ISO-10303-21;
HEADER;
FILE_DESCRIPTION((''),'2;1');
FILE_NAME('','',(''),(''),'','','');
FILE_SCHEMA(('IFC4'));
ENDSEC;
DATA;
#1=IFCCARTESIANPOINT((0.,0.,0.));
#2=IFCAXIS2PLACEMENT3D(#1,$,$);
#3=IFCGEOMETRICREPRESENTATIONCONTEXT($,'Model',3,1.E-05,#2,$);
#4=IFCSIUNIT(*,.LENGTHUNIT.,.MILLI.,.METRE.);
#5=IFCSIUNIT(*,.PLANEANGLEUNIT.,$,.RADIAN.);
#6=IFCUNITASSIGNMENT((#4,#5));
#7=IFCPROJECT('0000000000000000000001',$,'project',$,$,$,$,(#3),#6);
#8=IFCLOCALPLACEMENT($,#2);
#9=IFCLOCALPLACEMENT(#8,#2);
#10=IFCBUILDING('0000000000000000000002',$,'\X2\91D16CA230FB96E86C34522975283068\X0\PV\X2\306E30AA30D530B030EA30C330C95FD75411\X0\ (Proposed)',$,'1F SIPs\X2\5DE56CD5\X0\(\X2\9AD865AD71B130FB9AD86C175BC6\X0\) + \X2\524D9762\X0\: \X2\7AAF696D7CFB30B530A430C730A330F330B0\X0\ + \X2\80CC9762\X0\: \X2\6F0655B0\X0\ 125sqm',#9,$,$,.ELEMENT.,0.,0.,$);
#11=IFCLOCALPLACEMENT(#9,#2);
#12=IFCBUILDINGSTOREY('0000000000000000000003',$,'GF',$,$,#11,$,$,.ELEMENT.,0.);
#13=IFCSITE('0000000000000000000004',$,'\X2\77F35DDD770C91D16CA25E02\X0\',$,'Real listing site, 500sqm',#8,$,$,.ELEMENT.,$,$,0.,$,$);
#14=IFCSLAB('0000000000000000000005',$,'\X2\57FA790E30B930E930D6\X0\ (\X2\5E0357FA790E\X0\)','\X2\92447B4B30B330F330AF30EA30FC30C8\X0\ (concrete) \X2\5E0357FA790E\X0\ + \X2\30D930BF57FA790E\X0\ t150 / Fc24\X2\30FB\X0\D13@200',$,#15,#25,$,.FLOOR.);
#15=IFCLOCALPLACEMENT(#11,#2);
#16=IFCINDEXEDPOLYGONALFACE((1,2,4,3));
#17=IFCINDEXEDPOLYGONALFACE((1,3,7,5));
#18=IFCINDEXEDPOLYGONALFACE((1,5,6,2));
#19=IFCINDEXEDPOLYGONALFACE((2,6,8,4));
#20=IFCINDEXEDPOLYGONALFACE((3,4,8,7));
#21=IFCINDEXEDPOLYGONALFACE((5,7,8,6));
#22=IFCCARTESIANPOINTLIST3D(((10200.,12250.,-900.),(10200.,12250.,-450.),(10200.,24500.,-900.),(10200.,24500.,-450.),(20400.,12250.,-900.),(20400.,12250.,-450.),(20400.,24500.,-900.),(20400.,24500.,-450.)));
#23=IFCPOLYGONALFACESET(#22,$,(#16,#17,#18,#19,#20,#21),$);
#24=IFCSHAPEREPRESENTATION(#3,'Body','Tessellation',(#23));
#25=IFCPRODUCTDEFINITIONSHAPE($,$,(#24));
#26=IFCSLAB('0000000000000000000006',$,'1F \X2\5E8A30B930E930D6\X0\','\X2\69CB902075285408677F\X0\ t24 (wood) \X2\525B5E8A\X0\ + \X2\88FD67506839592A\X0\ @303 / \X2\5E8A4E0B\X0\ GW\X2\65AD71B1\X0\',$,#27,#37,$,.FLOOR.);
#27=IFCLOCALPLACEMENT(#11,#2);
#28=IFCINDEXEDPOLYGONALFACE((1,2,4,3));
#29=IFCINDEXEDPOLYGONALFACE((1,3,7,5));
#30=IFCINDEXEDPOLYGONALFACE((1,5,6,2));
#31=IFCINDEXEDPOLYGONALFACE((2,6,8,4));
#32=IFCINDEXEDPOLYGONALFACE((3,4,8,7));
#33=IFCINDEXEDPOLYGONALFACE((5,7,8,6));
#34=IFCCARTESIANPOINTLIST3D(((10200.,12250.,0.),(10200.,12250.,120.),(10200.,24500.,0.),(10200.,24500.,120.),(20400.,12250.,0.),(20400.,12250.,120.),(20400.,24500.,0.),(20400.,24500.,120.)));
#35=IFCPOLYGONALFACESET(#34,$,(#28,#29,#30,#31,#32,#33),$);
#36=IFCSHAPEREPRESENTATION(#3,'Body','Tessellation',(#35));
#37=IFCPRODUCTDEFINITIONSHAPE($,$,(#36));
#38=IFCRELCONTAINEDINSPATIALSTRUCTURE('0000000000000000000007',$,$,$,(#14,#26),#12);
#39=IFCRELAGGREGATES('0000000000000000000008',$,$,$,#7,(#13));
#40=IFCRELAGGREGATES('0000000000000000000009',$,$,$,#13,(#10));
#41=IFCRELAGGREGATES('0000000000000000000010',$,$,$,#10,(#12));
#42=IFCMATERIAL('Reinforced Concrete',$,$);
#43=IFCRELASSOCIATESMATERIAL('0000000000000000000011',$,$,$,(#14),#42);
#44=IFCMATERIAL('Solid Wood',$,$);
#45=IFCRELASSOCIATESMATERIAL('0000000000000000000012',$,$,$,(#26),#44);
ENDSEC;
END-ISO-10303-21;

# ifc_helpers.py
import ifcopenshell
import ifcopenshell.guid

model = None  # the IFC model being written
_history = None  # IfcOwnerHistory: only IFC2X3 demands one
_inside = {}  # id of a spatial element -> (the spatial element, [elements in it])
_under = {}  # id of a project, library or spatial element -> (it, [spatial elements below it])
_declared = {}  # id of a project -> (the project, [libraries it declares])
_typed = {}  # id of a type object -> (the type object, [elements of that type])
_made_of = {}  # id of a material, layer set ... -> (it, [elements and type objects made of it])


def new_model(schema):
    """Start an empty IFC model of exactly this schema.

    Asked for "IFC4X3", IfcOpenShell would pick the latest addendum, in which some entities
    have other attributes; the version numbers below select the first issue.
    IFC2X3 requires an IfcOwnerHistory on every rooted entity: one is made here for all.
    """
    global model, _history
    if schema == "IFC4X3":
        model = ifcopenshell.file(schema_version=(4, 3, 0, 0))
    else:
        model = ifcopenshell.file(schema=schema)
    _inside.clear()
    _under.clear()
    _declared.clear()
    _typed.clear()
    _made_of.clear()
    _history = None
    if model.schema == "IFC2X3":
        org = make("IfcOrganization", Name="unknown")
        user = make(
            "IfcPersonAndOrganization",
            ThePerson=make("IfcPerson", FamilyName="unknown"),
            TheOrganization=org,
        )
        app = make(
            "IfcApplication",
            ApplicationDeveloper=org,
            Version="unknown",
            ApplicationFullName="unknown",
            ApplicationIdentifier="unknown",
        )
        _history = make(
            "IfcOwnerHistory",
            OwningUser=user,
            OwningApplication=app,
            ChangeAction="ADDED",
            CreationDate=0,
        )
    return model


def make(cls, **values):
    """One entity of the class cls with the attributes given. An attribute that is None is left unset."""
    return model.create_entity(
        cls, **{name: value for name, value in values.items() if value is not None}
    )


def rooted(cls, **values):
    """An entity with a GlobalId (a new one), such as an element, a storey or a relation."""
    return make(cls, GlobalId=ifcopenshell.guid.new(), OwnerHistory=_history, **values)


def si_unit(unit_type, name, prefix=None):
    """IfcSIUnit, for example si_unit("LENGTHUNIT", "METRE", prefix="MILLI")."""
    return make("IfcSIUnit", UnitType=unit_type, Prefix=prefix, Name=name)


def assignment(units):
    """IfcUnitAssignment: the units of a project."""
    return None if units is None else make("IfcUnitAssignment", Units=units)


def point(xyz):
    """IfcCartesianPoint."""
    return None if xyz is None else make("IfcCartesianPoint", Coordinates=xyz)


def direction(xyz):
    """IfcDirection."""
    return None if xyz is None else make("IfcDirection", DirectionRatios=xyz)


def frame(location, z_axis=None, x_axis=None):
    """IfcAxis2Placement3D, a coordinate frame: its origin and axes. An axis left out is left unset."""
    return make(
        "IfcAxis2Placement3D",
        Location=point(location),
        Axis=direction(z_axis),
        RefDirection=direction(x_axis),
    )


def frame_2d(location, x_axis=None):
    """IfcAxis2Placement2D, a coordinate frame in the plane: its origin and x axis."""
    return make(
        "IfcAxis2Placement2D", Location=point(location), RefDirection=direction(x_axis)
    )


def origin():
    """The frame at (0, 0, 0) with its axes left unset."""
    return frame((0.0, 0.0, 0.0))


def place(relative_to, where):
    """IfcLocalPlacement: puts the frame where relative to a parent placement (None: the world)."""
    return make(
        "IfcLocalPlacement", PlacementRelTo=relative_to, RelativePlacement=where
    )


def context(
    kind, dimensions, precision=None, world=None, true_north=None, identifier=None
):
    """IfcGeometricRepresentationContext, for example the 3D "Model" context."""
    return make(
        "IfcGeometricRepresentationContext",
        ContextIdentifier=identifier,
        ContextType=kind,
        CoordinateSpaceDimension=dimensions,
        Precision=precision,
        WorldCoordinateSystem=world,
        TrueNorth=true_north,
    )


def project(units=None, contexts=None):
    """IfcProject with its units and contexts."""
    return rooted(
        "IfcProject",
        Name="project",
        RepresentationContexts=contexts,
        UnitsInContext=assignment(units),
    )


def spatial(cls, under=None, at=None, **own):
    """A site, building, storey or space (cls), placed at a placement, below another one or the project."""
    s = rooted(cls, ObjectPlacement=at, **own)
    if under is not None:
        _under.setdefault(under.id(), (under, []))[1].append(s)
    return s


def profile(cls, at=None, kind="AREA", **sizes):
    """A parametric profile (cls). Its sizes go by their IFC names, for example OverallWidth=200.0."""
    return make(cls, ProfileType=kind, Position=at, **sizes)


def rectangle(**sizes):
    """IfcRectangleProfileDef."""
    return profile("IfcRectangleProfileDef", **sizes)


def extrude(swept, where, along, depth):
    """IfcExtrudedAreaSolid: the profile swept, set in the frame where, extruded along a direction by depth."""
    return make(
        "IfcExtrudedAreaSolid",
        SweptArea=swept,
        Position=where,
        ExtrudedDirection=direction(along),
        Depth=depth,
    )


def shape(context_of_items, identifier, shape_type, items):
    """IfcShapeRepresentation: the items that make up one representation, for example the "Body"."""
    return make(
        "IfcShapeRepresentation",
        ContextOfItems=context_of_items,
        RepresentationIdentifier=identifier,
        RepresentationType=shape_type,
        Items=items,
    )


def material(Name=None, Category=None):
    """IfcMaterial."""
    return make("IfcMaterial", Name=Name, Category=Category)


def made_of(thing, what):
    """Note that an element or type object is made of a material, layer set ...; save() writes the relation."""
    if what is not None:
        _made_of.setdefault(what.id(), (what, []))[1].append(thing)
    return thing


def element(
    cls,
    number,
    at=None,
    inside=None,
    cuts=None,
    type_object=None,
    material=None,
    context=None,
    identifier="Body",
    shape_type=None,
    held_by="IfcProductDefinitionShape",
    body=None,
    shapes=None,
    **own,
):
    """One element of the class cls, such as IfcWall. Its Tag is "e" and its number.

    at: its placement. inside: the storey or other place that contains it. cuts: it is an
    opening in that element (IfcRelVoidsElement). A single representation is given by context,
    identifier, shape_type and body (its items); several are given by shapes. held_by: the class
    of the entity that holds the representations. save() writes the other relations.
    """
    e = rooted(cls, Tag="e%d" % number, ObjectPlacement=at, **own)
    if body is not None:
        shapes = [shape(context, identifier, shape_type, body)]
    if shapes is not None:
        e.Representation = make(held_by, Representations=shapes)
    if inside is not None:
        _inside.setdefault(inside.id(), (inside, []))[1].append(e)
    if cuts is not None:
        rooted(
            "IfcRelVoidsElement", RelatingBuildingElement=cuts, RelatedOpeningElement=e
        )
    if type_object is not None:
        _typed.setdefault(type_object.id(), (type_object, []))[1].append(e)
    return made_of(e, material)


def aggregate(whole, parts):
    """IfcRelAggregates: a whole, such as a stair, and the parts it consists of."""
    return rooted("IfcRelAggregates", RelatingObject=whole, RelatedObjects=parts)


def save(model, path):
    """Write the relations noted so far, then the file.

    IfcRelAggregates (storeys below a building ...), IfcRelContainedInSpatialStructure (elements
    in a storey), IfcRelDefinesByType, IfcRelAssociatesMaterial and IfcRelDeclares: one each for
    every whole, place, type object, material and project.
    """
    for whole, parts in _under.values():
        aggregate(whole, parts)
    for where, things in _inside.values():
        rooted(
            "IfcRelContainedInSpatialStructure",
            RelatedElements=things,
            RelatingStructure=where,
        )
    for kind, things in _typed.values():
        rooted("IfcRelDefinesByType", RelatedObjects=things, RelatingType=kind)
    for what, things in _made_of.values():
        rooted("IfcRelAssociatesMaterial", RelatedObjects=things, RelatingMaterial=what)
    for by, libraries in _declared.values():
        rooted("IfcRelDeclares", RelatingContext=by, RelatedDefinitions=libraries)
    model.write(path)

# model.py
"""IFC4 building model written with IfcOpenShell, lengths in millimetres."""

from ifc_helpers import new_model, si_unit, frame, frame_2d, origin, place, context, project, spatial, rectangle, extrude, material, element, save


model = new_model("IFC4")

# Units and contexts
model_context = context("Model", 3, precision=1e-05, world=origin())
ifc_project = project(units=[si_unit("LENGTHUNIT", "METRE", prefix="MILLI"), si_unit("PLANEANGLEUNIT", "RADIAN")], contexts=[model_context])

# Site, building, storey
site_placement = place(None, origin())
site = spatial("IfcSite", under=ifc_project, at=site_placement, Name="石川県金沢市", ObjectType="Real listing site, 500sqm", CompositionType="ELEMENT", RefElevation=0.0)
building_placement = place(site_placement, origin())
building = spatial("IfcBuilding", under=site, at=building_placement, Name="金沢・雨水利用とPVのオフグリッド志向 (Proposed)", ObjectType="1F SIPs工法(高断熱・高気密) + 前面: 窯業系サイディング + 背面: 漆喰 125sqm", CompositionType="ELEMENT", ElevationOfRefHeight=0.0, ElevationOfTerrain=0.0)
storey_placement = place(building_placement, origin())
storey = spatial("IfcBuildingStorey", under=building, at=storey_placement, Name="GF", CompositionType="ELEMENT", Elevation=0.0)

# Shared definitions
ifc_material_1 = material(Name="Solid Wood")

# Slabs
ifc_material_2 = material(Name="Reinforced Concrete")
slab_1_placement = place(storey_placement, frame((5100.0, 6125.0, -450.0)))
element("IfcSlab", 1, at=slab_1_placement, inside=storey, material=ifc_material_2, Name="基礎スラブ (布基礎)", Description="鉄筋コンクリート (concrete) 布基礎 + ベタ基礎 t150 / Fc24・D13@200", PredefinedType="FLOOR", context=model_context, shape_type="SweptSolid", body=[
    extrude(rectangle(XDim=10200.0, YDim=12250.0, at=frame_2d((5100.0, 6125.0))), frame((5100.0, 6125.0, -450.0)), (0.0, 0.0, 1.0), 450.0),
])
slab_2_placement = place(storey_placement, frame((5100.0, 6125.0, 0.0)))
element("IfcSlab", 2, at=slab_2_placement, inside=storey, material=ifc_material_1, Name="1F 床スラブ", Description="構造用合板 t24 (wood) 剛床 + 製材根太 @303 / 床下 GW断熱", PredefinedType="FLOOR", context=model_context, shape_type="SweptSolid", body=[
    extrude(rectangle(XDim=10200.0, YDim=12250.0, at=frame_2d((5100.0, 6125.0))), frame((5100.0, 6125.0, 0.0)), (0.0, 0.0, 1.0), 120.0),
])

save(model, "model.ifc")
